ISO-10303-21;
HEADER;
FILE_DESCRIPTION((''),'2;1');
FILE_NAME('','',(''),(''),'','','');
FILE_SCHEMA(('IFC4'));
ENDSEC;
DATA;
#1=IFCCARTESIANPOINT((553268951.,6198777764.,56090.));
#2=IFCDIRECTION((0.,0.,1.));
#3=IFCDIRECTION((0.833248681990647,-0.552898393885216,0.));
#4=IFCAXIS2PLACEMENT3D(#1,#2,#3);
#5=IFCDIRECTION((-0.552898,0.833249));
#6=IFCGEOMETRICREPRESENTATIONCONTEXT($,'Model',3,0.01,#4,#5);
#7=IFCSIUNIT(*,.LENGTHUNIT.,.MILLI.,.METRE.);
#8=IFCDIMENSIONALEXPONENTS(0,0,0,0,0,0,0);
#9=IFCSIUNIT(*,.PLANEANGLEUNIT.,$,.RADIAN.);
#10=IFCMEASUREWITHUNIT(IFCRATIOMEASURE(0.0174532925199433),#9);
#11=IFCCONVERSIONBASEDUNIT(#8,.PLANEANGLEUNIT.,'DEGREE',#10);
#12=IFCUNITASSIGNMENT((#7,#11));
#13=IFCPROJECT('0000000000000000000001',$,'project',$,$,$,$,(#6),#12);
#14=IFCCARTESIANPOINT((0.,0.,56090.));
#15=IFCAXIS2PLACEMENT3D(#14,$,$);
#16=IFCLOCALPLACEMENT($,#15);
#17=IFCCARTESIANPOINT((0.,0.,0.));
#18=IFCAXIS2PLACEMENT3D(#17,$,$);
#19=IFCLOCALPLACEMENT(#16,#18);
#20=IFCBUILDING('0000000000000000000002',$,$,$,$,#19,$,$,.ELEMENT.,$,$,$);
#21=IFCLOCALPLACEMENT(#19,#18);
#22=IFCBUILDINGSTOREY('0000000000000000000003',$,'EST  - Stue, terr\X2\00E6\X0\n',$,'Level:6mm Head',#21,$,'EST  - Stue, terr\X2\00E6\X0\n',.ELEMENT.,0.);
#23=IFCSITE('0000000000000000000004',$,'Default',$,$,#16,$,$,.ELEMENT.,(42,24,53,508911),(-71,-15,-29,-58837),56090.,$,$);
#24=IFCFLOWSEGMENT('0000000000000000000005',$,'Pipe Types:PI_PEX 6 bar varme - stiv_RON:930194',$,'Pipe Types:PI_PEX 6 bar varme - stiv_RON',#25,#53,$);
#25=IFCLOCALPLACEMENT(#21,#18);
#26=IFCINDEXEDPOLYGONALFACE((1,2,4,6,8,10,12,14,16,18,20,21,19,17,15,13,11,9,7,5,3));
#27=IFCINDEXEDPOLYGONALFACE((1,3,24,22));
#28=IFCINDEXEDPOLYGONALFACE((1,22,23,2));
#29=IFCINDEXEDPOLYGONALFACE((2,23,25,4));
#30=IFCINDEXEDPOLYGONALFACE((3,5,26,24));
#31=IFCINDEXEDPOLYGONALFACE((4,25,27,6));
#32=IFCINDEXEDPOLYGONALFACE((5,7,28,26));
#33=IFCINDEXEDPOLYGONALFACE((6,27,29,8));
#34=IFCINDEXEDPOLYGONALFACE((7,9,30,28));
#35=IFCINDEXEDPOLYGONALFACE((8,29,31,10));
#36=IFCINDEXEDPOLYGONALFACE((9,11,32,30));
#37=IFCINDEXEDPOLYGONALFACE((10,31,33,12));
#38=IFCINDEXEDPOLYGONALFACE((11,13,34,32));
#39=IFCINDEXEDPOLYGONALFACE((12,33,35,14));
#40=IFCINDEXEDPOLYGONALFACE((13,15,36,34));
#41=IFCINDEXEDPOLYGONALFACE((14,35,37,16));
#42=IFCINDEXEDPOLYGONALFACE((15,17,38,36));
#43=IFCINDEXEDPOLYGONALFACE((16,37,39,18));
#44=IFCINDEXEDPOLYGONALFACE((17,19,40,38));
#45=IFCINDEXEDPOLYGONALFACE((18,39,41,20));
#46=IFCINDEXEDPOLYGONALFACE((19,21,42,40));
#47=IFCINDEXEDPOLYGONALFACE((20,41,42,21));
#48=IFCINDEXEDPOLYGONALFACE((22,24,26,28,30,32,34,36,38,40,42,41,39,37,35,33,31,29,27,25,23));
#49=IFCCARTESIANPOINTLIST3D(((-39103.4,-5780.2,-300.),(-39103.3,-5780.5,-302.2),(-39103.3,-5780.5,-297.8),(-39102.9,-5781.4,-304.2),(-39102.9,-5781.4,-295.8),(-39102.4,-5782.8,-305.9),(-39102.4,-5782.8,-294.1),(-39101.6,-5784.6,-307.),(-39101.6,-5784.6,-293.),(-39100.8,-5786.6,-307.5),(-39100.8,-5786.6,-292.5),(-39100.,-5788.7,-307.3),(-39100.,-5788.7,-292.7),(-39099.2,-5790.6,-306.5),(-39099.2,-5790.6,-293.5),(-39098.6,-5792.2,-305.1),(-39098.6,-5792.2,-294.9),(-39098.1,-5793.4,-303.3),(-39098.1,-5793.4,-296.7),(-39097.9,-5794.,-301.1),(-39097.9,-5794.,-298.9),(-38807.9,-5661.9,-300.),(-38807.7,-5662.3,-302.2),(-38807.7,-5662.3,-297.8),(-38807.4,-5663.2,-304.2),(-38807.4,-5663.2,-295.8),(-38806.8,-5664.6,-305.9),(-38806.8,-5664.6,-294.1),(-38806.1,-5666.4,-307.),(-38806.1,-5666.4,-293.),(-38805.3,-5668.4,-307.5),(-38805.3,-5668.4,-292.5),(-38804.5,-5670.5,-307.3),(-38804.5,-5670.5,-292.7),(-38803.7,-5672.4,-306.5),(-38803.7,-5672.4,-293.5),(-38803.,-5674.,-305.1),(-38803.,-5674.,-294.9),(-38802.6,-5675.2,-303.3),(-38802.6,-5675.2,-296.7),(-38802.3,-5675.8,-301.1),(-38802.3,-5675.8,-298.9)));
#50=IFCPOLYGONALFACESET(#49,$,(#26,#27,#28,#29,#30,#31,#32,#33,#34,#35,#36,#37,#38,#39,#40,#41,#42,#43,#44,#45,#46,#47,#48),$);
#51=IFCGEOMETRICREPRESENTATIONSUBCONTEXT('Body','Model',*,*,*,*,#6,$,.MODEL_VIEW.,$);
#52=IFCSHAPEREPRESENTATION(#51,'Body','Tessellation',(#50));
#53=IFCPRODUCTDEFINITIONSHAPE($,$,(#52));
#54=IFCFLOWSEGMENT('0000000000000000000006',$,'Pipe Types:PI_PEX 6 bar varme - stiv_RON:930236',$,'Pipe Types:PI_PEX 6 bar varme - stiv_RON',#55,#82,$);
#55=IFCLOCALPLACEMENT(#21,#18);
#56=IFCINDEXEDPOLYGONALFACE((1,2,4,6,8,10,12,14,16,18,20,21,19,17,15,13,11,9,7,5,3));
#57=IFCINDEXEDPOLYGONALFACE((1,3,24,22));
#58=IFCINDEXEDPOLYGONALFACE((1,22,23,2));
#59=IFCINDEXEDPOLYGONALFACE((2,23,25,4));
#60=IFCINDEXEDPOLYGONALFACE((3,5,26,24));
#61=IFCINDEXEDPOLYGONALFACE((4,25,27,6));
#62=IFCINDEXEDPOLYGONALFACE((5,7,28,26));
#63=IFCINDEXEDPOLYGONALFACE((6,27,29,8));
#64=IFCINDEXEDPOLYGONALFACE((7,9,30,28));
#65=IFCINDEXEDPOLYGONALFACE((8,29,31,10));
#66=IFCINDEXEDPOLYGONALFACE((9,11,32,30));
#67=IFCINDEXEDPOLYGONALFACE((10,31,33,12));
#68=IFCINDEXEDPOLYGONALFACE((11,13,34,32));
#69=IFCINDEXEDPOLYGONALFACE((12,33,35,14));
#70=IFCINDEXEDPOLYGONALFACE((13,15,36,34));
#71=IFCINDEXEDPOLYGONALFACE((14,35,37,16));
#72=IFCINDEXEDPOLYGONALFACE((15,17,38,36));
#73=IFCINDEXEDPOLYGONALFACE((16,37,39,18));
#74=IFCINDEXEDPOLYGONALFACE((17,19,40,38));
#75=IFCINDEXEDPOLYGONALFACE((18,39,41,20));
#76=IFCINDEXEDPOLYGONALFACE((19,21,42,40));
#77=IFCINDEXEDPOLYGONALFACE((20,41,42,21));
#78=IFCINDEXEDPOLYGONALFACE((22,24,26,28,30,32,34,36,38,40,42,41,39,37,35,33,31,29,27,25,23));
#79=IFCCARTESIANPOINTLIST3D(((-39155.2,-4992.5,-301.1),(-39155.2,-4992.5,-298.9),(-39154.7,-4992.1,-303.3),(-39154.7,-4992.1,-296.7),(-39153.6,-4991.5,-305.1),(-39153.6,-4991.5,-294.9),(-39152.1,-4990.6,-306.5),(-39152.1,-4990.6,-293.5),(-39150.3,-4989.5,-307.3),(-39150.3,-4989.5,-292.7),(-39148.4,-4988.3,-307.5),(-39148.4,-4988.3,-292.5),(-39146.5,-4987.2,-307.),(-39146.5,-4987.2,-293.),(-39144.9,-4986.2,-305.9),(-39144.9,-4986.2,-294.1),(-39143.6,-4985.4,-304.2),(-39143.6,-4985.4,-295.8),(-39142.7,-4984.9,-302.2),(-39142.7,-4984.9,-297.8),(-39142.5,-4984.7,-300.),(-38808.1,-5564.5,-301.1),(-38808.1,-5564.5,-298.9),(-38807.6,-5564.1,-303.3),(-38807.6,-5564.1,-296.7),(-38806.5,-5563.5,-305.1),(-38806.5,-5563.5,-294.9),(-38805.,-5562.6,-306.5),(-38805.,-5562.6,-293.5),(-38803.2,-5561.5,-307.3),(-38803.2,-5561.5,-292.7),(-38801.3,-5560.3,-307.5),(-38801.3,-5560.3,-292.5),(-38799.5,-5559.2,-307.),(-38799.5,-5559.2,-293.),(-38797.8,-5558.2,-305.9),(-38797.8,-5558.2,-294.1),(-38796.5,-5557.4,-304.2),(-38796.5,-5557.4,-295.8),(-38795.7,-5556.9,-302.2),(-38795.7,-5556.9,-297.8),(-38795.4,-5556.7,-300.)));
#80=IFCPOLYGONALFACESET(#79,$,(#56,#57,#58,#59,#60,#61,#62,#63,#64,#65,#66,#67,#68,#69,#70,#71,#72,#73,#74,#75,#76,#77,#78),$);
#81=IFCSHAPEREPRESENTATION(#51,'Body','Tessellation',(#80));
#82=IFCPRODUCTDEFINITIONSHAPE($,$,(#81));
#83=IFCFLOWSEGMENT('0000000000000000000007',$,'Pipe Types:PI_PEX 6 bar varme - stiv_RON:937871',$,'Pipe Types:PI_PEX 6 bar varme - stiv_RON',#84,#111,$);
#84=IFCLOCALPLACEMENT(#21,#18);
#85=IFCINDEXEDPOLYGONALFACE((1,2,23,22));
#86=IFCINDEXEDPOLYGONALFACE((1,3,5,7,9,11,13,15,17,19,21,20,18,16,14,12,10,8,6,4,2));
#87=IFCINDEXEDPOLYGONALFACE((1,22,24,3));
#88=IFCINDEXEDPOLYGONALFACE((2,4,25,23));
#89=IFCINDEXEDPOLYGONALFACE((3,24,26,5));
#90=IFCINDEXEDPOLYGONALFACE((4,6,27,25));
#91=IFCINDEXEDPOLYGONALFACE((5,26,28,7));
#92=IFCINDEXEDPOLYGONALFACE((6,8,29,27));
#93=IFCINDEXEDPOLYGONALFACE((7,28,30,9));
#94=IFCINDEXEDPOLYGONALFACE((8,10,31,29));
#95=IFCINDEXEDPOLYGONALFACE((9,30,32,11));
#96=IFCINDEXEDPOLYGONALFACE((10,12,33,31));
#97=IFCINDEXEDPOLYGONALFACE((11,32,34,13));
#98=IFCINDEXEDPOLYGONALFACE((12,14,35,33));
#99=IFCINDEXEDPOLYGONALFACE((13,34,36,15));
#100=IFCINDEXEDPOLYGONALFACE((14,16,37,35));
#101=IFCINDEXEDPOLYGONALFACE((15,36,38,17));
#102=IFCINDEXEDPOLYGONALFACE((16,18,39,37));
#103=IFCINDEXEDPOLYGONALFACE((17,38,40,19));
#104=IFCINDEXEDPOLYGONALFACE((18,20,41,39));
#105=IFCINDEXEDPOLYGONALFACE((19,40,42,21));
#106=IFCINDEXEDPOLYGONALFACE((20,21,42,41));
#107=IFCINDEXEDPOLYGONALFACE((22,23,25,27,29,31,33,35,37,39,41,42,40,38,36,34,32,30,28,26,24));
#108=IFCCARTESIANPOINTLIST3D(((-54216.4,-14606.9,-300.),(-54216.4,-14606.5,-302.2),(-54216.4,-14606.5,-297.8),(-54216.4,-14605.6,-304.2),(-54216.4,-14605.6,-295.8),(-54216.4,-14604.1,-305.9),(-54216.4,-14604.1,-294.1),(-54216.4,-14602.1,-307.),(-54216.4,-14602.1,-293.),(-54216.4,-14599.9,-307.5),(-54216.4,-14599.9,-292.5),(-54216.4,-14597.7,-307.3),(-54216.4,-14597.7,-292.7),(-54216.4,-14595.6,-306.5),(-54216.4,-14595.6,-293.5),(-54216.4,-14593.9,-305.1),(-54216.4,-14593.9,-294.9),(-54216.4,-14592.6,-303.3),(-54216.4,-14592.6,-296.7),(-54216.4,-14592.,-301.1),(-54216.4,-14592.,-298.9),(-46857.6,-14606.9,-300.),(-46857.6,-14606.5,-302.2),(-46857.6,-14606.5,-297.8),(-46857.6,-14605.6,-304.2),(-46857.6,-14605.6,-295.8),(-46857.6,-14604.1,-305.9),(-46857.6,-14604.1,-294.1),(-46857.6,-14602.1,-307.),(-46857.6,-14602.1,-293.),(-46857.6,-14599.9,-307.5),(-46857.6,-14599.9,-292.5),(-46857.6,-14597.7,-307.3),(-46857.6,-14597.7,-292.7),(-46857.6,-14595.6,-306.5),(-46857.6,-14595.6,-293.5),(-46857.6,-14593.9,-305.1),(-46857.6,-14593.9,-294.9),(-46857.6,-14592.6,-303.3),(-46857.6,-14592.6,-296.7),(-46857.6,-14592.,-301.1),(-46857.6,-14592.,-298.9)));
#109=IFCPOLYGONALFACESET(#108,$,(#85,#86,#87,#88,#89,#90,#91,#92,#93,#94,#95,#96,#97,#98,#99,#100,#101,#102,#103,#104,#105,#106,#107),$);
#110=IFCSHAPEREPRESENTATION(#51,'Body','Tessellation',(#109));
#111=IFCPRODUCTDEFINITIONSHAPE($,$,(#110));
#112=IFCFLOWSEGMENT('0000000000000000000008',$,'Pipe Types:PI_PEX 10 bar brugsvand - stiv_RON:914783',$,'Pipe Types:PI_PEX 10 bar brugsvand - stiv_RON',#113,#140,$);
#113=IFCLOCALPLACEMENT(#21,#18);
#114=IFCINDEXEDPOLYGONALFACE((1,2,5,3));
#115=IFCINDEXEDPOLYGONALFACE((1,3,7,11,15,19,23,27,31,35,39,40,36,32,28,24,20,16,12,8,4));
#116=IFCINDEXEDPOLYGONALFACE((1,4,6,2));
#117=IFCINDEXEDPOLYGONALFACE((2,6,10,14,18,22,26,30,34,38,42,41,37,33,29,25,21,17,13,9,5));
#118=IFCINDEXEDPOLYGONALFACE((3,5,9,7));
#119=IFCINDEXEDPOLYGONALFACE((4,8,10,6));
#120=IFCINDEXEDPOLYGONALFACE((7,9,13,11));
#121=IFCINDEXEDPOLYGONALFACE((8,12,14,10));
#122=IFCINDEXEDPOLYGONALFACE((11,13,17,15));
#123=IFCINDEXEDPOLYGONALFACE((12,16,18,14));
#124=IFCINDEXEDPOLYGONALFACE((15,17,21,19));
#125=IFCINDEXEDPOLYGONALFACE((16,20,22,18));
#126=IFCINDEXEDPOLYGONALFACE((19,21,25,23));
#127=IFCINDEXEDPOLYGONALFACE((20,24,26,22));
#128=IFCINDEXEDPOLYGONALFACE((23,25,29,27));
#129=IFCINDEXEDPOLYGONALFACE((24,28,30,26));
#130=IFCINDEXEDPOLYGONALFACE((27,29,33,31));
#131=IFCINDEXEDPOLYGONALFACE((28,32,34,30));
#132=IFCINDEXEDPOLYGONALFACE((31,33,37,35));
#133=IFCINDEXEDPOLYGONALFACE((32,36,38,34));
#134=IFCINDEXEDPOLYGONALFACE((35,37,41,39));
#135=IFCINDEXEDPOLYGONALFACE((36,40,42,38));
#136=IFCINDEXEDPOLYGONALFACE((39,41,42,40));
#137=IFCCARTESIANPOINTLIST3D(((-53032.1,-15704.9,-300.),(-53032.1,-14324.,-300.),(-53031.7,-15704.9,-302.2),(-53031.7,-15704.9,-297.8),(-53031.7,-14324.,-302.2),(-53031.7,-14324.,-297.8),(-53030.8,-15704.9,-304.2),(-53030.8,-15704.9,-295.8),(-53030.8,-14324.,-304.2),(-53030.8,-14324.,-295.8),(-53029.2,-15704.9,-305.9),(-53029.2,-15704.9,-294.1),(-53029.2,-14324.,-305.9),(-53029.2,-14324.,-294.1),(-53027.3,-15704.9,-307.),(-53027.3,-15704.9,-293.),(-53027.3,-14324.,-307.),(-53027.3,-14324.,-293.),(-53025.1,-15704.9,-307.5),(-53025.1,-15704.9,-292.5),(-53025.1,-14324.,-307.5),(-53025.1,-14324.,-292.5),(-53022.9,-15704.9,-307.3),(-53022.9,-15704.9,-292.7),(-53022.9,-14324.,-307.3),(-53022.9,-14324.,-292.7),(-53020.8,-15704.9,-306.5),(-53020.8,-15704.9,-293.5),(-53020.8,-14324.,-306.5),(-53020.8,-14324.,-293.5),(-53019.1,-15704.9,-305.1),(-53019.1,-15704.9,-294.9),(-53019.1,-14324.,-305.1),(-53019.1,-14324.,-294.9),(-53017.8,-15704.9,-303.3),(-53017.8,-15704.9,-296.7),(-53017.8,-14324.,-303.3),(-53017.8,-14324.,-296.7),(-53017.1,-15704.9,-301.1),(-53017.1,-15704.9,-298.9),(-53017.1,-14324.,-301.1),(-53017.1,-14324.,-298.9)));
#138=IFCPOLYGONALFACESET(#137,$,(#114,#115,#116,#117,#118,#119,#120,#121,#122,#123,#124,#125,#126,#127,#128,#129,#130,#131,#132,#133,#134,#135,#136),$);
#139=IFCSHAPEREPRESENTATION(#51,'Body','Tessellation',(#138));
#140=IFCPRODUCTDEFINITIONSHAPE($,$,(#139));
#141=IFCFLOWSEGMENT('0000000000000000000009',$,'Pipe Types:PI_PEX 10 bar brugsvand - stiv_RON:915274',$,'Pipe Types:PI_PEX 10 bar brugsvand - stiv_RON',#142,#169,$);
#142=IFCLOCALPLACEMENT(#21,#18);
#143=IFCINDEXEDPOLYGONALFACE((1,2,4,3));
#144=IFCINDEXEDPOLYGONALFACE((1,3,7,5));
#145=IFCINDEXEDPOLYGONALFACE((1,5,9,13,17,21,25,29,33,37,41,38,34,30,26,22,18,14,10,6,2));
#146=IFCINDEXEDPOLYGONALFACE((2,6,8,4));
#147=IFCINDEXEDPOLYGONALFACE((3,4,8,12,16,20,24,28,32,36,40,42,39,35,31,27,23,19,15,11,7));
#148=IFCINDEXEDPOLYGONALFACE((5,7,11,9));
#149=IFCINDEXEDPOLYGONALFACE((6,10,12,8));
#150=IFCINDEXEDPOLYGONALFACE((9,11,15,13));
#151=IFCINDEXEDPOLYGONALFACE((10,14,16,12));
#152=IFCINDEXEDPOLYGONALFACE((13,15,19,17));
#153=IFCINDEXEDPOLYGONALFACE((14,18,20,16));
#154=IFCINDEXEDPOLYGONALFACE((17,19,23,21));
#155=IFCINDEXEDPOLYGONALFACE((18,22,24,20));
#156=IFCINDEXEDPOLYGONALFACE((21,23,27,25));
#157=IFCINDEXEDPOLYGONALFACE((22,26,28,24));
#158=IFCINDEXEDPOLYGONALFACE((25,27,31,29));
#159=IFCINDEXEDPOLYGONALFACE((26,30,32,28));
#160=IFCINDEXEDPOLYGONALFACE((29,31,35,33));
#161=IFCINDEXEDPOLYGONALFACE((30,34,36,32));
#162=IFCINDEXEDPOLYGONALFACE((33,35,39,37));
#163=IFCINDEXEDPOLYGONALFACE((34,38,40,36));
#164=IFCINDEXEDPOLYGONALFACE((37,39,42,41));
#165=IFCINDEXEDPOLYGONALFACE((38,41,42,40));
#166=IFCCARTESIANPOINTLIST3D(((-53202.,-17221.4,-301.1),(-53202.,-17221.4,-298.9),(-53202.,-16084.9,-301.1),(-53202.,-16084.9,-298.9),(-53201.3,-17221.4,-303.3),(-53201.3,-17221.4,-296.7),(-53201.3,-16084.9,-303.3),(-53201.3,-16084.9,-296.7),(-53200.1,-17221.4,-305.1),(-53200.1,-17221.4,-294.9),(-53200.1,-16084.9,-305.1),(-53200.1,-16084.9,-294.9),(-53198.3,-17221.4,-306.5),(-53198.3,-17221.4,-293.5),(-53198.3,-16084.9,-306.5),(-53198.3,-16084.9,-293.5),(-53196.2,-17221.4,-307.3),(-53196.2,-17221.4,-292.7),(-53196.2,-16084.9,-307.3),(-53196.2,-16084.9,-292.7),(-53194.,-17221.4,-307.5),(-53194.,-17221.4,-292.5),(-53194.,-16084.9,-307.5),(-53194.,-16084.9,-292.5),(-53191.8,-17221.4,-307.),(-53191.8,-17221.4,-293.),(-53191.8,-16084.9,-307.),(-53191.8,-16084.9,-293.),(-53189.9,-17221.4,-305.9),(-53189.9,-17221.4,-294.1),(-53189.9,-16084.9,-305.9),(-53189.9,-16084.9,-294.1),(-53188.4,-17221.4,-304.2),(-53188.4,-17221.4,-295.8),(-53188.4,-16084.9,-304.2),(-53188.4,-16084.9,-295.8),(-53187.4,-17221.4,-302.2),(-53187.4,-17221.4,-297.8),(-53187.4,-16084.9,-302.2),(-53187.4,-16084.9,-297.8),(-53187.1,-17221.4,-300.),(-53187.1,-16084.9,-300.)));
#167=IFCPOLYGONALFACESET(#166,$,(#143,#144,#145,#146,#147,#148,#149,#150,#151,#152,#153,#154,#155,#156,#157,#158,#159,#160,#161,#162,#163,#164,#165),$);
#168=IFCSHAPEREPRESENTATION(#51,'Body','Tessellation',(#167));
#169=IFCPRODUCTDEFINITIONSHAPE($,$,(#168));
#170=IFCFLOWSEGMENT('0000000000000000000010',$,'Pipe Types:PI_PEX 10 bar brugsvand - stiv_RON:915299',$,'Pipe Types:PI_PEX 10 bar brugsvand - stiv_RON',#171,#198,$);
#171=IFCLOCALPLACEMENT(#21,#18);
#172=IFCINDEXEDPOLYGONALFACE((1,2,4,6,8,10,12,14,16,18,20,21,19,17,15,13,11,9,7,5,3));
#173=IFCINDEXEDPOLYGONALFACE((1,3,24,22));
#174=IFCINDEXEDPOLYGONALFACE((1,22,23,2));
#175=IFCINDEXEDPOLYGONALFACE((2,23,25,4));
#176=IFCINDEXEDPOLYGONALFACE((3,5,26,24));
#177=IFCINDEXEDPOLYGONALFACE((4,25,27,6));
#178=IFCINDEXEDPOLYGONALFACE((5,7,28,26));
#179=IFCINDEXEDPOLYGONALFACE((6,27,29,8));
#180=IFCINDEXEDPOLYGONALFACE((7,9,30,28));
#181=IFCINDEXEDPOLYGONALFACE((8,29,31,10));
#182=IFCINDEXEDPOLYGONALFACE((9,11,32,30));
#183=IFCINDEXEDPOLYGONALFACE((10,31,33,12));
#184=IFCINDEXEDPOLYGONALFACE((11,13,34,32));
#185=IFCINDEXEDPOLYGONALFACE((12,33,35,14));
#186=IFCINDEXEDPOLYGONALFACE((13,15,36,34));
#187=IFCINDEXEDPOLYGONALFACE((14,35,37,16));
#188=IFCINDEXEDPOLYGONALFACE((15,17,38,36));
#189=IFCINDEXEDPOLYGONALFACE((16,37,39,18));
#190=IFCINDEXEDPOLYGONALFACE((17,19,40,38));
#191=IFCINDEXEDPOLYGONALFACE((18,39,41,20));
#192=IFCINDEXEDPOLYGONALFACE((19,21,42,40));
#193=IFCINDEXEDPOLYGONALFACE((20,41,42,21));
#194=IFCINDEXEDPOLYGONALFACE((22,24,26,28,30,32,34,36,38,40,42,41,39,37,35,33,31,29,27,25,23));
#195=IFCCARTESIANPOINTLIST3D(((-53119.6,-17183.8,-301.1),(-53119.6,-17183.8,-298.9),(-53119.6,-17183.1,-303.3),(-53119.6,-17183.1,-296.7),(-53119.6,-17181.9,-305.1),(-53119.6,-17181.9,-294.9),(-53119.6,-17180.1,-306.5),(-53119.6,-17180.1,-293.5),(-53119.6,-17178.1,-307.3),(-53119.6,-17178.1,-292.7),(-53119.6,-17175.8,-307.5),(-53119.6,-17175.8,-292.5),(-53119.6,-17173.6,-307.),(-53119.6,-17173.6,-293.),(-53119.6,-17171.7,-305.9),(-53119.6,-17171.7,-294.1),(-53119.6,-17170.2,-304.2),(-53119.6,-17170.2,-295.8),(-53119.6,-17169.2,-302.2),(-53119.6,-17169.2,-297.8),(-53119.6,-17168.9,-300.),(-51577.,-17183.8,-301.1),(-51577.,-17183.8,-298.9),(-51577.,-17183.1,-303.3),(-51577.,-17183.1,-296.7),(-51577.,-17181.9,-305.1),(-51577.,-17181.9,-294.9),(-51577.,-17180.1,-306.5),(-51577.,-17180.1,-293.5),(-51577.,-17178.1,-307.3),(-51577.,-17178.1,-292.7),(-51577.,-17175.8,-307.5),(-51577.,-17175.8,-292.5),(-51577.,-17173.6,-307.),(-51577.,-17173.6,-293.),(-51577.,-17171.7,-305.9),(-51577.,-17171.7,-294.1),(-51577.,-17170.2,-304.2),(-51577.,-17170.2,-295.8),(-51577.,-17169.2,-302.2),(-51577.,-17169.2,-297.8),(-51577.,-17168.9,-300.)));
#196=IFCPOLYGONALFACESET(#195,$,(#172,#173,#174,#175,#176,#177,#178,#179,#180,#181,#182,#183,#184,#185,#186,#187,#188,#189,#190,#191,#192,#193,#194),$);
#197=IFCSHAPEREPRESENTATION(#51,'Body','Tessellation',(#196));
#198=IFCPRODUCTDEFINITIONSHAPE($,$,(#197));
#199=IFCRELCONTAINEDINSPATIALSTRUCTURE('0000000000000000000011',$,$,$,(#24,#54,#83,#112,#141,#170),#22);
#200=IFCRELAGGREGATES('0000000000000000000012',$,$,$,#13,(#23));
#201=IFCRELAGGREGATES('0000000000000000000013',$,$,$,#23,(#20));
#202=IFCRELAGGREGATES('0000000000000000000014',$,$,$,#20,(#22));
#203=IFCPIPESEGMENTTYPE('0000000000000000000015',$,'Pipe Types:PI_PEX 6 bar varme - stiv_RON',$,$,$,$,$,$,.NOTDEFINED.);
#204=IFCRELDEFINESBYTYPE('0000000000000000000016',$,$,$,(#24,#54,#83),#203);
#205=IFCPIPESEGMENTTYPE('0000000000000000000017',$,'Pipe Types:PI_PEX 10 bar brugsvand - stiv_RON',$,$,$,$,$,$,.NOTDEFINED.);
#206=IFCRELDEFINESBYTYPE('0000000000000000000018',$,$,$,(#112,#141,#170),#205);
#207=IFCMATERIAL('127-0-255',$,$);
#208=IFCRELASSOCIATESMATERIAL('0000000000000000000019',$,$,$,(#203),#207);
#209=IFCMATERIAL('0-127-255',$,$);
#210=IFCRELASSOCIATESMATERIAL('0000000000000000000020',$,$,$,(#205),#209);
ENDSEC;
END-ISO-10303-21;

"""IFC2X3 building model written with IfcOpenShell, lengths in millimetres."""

from ifc_helpers import new_model, entity, si_unit, converted_unit, direction, frame, frame_2d, origin, origin_2d_with_axis, place, context, subcontext, project, spatial, circle, extrude, material, type_object, element, save


model = new_model("IFC2X3")

# Units and contexts
model_context = context("Model", 3, precision=0.01, world=frame((553268951.0, 6198777764.0, 56090.0), z_axis=(0.0, 0.0, 1.0), x_axis=(0.833248681990647, -0.552898393885216, 0.0)), true_north=direction((-0.552898, 0.833249)))
body_context = subcontext(model_context, "Body", "Model", "MODEL_VIEW")
ifc_project = project(units=[si_unit("LENGTHUNIT", "METRE", prefix="MILLI"), converted_unit("PLANEANGLEUNIT", "DEGREE", entity("IfcRatioMeasure", 0.0174532925199433), si_unit("PLANEANGLEUNIT", "RADIAN"), dimensions=[0, 0, 0, 0, 0, 0, 0])], contexts=[model_context])

# Site, building, storey
site_placement = place(None, frame((0.0, 0.0, 56090.0)))
site = spatial("IfcSite", under=ifc_project, at=site_placement, Name="Default", CompositionType="ELEMENT", RefLatitude=(42, 24, 53, 508911), RefLongitude=(-71, -15, -29, -58837), RefElevation=56090.0)
building_placement = place(site_placement, origin())
building = spatial("IfcBuilding", under=site, at=building_placement, CompositionType="ELEMENT")
storey_placement = place(building_placement, frame((0.0, 0.0, 0.0)))
storey = spatial("IfcBuildingStorey", under=building, at=storey_placement, Name="EST  - Stue, terræn", ObjectType="Level:6mm Head", LongName="EST  - Stue, terræn", CompositionType="ELEMENT", Elevation=0.0)

# Flow segments
ifc_material_1 = material(Name="127-0-255")
pipe_segment_type_1 = type_object("IfcPipeSegmentType", Name="Pipe Types:PI_PEX 6 bar varme - stiv_RON", PredefinedType="NOTDEFINED", material=ifc_material_1)
flow_segment_1_placement = place(storey_placement, origin())
element("IfcFlowSegment", 1, at=flow_segment_1_placement, inside=storey, type_object=pipe_segment_type_1, Name="Pipe Types:PI_PEX 6 bar varme - stiv_RON:930194", ObjectType="Pipe Types:PI_PEX 6 bar varme - stiv_RON", context=body_context, shape_type="SweptSolid", body=[
    extrude(circle(Radius=7.5, at=origin_2d_with_axis()), frame((-39100.6, -5787.1, -300.0), z_axis=(0.928475, 0.371394, 0.0), x_axis=(-0.371394, 0.928475, 0.0)), (0.0, 0.0, 1.0), 318.3),
])
flow_segment_2_placement = place(storey_placement, origin())
element("IfcFlowSegment", 2, at=flow_segment_2_placement, inside=storey, type_object=pipe_segment_type_1, Name="Pipe Types:PI_PEX 6 bar varme - stiv_RON:930236", ObjectType="Pipe Types:PI_PEX 6 bar varme - stiv_RON", context=body_context, shape_type="SweptSolid", body=[
    extrude(circle(Radius=7.5, at=origin_2d_with_axis()), frame((-39148.9, -4988.6, -300.0), z_axis=(0.51875, -0.854926, 0.0), x_axis=(0.854926, 0.51875, 0.0)), (0.0, 0.0, 1.0), 669.1),
])
flow_segment_3_placement = place(storey_placement, origin())
element("IfcFlowSegment", 3, at=flow_segment_3_placement, inside=storey, type_object=pipe_segment_type_1, Name="Pipe Types:PI_PEX 6 bar varme - stiv_RON:937871", ObjectType="Pipe Types:PI_PEX 6 bar varme - stiv_RON", context=body_context, shape_type="SweptSolid", body=[
    extrude(circle(Radius=7.5, at=origin_2d_with_axis()), frame((-54216.4, -14599.4, -300.0), z_axis=(1.0, 0.0, 0.0), x_axis=(0.0, -1.0, 0.0)), (0.0, 0.0, 1.0), 7358.8),
])
ifc_material_2 = material(Name="0-127-255")
pipe_segment_type_2 = type_object("IfcPipeSegmentType", Name="Pipe Types:PI_PEX 10 bar brugsvand - stiv_RON", PredefinedType="NOTDEFINED", material=ifc_material_2)
flow_segment_4_placement = place(storey_placement, origin())
element("IfcFlowSegment", 4, at=flow_segment_4_placement, inside=storey, type_object=pipe_segment_type_2, Name="Pipe Types:PI_PEX 10 bar brugsvand - stiv_RON:914783", ObjectType="Pipe Types:PI_PEX 10 bar brugsvand - stiv_RON", context=body_context, shape_type="SweptSolid", body=[
    extrude(circle(Radius=7.5, at=origin_2d_with_axis()), frame((-53024.6, -15704.9, -300.0), z_axis=(0.0, 1.0, 0.0), x_axis=(-1.0, 0.0, 0.0)), (0.0, 0.0, 1.0), 1380.9),
])
flow_segment_5_placement = place(storey_placement, origin())
element("IfcFlowSegment", 5, at=flow_segment_5_placement, inside=storey, type_object=pipe_segment_type_2, Name="Pipe Types:PI_PEX 10 bar brugsvand - stiv_RON:915274", ObjectType="Pipe Types:PI_PEX 10 bar brugsvand - stiv_RON", context=body_context, shape_type="SweptSolid", body=[
    extrude(circle(Radius=7.5, at=frame_2d((0.0, 0.0), x_axis=(1.0, 0.0))), frame((-53194.6, -17221.4, -300.0), z_axis=(0.0, 1.0, 0.0), x_axis=(1.0, 0.0, 0.0)), (0.0, 0.0, 1.0), 1136.5),
])
flow_segment_6_placement = place(storey_placement, origin())
element("IfcFlowSegment", 6, at=flow_segment_6_placement, inside=storey, type_object=pipe_segment_type_2, Name="Pipe Types:PI_PEX 10 bar brugsvand - stiv_RON:915299", ObjectType="Pipe Types:PI_PEX 10 bar brugsvand - stiv_RON", context=body_context, shape_type="SweptSolid", body=[
    extrude(circle(Radius=7.5, at=frame_2d((0.0, 0.0), x_axis=(1.0, 0.0))), frame((-53119.6, -17176.4, -300.0), z_axis=(1.0, 0.0, 0.0), x_axis=(0.0, 1.0, 0.0)), (0.0, 0.0, 1.0), 1542.6),
])

save(model, "model.ifc")
